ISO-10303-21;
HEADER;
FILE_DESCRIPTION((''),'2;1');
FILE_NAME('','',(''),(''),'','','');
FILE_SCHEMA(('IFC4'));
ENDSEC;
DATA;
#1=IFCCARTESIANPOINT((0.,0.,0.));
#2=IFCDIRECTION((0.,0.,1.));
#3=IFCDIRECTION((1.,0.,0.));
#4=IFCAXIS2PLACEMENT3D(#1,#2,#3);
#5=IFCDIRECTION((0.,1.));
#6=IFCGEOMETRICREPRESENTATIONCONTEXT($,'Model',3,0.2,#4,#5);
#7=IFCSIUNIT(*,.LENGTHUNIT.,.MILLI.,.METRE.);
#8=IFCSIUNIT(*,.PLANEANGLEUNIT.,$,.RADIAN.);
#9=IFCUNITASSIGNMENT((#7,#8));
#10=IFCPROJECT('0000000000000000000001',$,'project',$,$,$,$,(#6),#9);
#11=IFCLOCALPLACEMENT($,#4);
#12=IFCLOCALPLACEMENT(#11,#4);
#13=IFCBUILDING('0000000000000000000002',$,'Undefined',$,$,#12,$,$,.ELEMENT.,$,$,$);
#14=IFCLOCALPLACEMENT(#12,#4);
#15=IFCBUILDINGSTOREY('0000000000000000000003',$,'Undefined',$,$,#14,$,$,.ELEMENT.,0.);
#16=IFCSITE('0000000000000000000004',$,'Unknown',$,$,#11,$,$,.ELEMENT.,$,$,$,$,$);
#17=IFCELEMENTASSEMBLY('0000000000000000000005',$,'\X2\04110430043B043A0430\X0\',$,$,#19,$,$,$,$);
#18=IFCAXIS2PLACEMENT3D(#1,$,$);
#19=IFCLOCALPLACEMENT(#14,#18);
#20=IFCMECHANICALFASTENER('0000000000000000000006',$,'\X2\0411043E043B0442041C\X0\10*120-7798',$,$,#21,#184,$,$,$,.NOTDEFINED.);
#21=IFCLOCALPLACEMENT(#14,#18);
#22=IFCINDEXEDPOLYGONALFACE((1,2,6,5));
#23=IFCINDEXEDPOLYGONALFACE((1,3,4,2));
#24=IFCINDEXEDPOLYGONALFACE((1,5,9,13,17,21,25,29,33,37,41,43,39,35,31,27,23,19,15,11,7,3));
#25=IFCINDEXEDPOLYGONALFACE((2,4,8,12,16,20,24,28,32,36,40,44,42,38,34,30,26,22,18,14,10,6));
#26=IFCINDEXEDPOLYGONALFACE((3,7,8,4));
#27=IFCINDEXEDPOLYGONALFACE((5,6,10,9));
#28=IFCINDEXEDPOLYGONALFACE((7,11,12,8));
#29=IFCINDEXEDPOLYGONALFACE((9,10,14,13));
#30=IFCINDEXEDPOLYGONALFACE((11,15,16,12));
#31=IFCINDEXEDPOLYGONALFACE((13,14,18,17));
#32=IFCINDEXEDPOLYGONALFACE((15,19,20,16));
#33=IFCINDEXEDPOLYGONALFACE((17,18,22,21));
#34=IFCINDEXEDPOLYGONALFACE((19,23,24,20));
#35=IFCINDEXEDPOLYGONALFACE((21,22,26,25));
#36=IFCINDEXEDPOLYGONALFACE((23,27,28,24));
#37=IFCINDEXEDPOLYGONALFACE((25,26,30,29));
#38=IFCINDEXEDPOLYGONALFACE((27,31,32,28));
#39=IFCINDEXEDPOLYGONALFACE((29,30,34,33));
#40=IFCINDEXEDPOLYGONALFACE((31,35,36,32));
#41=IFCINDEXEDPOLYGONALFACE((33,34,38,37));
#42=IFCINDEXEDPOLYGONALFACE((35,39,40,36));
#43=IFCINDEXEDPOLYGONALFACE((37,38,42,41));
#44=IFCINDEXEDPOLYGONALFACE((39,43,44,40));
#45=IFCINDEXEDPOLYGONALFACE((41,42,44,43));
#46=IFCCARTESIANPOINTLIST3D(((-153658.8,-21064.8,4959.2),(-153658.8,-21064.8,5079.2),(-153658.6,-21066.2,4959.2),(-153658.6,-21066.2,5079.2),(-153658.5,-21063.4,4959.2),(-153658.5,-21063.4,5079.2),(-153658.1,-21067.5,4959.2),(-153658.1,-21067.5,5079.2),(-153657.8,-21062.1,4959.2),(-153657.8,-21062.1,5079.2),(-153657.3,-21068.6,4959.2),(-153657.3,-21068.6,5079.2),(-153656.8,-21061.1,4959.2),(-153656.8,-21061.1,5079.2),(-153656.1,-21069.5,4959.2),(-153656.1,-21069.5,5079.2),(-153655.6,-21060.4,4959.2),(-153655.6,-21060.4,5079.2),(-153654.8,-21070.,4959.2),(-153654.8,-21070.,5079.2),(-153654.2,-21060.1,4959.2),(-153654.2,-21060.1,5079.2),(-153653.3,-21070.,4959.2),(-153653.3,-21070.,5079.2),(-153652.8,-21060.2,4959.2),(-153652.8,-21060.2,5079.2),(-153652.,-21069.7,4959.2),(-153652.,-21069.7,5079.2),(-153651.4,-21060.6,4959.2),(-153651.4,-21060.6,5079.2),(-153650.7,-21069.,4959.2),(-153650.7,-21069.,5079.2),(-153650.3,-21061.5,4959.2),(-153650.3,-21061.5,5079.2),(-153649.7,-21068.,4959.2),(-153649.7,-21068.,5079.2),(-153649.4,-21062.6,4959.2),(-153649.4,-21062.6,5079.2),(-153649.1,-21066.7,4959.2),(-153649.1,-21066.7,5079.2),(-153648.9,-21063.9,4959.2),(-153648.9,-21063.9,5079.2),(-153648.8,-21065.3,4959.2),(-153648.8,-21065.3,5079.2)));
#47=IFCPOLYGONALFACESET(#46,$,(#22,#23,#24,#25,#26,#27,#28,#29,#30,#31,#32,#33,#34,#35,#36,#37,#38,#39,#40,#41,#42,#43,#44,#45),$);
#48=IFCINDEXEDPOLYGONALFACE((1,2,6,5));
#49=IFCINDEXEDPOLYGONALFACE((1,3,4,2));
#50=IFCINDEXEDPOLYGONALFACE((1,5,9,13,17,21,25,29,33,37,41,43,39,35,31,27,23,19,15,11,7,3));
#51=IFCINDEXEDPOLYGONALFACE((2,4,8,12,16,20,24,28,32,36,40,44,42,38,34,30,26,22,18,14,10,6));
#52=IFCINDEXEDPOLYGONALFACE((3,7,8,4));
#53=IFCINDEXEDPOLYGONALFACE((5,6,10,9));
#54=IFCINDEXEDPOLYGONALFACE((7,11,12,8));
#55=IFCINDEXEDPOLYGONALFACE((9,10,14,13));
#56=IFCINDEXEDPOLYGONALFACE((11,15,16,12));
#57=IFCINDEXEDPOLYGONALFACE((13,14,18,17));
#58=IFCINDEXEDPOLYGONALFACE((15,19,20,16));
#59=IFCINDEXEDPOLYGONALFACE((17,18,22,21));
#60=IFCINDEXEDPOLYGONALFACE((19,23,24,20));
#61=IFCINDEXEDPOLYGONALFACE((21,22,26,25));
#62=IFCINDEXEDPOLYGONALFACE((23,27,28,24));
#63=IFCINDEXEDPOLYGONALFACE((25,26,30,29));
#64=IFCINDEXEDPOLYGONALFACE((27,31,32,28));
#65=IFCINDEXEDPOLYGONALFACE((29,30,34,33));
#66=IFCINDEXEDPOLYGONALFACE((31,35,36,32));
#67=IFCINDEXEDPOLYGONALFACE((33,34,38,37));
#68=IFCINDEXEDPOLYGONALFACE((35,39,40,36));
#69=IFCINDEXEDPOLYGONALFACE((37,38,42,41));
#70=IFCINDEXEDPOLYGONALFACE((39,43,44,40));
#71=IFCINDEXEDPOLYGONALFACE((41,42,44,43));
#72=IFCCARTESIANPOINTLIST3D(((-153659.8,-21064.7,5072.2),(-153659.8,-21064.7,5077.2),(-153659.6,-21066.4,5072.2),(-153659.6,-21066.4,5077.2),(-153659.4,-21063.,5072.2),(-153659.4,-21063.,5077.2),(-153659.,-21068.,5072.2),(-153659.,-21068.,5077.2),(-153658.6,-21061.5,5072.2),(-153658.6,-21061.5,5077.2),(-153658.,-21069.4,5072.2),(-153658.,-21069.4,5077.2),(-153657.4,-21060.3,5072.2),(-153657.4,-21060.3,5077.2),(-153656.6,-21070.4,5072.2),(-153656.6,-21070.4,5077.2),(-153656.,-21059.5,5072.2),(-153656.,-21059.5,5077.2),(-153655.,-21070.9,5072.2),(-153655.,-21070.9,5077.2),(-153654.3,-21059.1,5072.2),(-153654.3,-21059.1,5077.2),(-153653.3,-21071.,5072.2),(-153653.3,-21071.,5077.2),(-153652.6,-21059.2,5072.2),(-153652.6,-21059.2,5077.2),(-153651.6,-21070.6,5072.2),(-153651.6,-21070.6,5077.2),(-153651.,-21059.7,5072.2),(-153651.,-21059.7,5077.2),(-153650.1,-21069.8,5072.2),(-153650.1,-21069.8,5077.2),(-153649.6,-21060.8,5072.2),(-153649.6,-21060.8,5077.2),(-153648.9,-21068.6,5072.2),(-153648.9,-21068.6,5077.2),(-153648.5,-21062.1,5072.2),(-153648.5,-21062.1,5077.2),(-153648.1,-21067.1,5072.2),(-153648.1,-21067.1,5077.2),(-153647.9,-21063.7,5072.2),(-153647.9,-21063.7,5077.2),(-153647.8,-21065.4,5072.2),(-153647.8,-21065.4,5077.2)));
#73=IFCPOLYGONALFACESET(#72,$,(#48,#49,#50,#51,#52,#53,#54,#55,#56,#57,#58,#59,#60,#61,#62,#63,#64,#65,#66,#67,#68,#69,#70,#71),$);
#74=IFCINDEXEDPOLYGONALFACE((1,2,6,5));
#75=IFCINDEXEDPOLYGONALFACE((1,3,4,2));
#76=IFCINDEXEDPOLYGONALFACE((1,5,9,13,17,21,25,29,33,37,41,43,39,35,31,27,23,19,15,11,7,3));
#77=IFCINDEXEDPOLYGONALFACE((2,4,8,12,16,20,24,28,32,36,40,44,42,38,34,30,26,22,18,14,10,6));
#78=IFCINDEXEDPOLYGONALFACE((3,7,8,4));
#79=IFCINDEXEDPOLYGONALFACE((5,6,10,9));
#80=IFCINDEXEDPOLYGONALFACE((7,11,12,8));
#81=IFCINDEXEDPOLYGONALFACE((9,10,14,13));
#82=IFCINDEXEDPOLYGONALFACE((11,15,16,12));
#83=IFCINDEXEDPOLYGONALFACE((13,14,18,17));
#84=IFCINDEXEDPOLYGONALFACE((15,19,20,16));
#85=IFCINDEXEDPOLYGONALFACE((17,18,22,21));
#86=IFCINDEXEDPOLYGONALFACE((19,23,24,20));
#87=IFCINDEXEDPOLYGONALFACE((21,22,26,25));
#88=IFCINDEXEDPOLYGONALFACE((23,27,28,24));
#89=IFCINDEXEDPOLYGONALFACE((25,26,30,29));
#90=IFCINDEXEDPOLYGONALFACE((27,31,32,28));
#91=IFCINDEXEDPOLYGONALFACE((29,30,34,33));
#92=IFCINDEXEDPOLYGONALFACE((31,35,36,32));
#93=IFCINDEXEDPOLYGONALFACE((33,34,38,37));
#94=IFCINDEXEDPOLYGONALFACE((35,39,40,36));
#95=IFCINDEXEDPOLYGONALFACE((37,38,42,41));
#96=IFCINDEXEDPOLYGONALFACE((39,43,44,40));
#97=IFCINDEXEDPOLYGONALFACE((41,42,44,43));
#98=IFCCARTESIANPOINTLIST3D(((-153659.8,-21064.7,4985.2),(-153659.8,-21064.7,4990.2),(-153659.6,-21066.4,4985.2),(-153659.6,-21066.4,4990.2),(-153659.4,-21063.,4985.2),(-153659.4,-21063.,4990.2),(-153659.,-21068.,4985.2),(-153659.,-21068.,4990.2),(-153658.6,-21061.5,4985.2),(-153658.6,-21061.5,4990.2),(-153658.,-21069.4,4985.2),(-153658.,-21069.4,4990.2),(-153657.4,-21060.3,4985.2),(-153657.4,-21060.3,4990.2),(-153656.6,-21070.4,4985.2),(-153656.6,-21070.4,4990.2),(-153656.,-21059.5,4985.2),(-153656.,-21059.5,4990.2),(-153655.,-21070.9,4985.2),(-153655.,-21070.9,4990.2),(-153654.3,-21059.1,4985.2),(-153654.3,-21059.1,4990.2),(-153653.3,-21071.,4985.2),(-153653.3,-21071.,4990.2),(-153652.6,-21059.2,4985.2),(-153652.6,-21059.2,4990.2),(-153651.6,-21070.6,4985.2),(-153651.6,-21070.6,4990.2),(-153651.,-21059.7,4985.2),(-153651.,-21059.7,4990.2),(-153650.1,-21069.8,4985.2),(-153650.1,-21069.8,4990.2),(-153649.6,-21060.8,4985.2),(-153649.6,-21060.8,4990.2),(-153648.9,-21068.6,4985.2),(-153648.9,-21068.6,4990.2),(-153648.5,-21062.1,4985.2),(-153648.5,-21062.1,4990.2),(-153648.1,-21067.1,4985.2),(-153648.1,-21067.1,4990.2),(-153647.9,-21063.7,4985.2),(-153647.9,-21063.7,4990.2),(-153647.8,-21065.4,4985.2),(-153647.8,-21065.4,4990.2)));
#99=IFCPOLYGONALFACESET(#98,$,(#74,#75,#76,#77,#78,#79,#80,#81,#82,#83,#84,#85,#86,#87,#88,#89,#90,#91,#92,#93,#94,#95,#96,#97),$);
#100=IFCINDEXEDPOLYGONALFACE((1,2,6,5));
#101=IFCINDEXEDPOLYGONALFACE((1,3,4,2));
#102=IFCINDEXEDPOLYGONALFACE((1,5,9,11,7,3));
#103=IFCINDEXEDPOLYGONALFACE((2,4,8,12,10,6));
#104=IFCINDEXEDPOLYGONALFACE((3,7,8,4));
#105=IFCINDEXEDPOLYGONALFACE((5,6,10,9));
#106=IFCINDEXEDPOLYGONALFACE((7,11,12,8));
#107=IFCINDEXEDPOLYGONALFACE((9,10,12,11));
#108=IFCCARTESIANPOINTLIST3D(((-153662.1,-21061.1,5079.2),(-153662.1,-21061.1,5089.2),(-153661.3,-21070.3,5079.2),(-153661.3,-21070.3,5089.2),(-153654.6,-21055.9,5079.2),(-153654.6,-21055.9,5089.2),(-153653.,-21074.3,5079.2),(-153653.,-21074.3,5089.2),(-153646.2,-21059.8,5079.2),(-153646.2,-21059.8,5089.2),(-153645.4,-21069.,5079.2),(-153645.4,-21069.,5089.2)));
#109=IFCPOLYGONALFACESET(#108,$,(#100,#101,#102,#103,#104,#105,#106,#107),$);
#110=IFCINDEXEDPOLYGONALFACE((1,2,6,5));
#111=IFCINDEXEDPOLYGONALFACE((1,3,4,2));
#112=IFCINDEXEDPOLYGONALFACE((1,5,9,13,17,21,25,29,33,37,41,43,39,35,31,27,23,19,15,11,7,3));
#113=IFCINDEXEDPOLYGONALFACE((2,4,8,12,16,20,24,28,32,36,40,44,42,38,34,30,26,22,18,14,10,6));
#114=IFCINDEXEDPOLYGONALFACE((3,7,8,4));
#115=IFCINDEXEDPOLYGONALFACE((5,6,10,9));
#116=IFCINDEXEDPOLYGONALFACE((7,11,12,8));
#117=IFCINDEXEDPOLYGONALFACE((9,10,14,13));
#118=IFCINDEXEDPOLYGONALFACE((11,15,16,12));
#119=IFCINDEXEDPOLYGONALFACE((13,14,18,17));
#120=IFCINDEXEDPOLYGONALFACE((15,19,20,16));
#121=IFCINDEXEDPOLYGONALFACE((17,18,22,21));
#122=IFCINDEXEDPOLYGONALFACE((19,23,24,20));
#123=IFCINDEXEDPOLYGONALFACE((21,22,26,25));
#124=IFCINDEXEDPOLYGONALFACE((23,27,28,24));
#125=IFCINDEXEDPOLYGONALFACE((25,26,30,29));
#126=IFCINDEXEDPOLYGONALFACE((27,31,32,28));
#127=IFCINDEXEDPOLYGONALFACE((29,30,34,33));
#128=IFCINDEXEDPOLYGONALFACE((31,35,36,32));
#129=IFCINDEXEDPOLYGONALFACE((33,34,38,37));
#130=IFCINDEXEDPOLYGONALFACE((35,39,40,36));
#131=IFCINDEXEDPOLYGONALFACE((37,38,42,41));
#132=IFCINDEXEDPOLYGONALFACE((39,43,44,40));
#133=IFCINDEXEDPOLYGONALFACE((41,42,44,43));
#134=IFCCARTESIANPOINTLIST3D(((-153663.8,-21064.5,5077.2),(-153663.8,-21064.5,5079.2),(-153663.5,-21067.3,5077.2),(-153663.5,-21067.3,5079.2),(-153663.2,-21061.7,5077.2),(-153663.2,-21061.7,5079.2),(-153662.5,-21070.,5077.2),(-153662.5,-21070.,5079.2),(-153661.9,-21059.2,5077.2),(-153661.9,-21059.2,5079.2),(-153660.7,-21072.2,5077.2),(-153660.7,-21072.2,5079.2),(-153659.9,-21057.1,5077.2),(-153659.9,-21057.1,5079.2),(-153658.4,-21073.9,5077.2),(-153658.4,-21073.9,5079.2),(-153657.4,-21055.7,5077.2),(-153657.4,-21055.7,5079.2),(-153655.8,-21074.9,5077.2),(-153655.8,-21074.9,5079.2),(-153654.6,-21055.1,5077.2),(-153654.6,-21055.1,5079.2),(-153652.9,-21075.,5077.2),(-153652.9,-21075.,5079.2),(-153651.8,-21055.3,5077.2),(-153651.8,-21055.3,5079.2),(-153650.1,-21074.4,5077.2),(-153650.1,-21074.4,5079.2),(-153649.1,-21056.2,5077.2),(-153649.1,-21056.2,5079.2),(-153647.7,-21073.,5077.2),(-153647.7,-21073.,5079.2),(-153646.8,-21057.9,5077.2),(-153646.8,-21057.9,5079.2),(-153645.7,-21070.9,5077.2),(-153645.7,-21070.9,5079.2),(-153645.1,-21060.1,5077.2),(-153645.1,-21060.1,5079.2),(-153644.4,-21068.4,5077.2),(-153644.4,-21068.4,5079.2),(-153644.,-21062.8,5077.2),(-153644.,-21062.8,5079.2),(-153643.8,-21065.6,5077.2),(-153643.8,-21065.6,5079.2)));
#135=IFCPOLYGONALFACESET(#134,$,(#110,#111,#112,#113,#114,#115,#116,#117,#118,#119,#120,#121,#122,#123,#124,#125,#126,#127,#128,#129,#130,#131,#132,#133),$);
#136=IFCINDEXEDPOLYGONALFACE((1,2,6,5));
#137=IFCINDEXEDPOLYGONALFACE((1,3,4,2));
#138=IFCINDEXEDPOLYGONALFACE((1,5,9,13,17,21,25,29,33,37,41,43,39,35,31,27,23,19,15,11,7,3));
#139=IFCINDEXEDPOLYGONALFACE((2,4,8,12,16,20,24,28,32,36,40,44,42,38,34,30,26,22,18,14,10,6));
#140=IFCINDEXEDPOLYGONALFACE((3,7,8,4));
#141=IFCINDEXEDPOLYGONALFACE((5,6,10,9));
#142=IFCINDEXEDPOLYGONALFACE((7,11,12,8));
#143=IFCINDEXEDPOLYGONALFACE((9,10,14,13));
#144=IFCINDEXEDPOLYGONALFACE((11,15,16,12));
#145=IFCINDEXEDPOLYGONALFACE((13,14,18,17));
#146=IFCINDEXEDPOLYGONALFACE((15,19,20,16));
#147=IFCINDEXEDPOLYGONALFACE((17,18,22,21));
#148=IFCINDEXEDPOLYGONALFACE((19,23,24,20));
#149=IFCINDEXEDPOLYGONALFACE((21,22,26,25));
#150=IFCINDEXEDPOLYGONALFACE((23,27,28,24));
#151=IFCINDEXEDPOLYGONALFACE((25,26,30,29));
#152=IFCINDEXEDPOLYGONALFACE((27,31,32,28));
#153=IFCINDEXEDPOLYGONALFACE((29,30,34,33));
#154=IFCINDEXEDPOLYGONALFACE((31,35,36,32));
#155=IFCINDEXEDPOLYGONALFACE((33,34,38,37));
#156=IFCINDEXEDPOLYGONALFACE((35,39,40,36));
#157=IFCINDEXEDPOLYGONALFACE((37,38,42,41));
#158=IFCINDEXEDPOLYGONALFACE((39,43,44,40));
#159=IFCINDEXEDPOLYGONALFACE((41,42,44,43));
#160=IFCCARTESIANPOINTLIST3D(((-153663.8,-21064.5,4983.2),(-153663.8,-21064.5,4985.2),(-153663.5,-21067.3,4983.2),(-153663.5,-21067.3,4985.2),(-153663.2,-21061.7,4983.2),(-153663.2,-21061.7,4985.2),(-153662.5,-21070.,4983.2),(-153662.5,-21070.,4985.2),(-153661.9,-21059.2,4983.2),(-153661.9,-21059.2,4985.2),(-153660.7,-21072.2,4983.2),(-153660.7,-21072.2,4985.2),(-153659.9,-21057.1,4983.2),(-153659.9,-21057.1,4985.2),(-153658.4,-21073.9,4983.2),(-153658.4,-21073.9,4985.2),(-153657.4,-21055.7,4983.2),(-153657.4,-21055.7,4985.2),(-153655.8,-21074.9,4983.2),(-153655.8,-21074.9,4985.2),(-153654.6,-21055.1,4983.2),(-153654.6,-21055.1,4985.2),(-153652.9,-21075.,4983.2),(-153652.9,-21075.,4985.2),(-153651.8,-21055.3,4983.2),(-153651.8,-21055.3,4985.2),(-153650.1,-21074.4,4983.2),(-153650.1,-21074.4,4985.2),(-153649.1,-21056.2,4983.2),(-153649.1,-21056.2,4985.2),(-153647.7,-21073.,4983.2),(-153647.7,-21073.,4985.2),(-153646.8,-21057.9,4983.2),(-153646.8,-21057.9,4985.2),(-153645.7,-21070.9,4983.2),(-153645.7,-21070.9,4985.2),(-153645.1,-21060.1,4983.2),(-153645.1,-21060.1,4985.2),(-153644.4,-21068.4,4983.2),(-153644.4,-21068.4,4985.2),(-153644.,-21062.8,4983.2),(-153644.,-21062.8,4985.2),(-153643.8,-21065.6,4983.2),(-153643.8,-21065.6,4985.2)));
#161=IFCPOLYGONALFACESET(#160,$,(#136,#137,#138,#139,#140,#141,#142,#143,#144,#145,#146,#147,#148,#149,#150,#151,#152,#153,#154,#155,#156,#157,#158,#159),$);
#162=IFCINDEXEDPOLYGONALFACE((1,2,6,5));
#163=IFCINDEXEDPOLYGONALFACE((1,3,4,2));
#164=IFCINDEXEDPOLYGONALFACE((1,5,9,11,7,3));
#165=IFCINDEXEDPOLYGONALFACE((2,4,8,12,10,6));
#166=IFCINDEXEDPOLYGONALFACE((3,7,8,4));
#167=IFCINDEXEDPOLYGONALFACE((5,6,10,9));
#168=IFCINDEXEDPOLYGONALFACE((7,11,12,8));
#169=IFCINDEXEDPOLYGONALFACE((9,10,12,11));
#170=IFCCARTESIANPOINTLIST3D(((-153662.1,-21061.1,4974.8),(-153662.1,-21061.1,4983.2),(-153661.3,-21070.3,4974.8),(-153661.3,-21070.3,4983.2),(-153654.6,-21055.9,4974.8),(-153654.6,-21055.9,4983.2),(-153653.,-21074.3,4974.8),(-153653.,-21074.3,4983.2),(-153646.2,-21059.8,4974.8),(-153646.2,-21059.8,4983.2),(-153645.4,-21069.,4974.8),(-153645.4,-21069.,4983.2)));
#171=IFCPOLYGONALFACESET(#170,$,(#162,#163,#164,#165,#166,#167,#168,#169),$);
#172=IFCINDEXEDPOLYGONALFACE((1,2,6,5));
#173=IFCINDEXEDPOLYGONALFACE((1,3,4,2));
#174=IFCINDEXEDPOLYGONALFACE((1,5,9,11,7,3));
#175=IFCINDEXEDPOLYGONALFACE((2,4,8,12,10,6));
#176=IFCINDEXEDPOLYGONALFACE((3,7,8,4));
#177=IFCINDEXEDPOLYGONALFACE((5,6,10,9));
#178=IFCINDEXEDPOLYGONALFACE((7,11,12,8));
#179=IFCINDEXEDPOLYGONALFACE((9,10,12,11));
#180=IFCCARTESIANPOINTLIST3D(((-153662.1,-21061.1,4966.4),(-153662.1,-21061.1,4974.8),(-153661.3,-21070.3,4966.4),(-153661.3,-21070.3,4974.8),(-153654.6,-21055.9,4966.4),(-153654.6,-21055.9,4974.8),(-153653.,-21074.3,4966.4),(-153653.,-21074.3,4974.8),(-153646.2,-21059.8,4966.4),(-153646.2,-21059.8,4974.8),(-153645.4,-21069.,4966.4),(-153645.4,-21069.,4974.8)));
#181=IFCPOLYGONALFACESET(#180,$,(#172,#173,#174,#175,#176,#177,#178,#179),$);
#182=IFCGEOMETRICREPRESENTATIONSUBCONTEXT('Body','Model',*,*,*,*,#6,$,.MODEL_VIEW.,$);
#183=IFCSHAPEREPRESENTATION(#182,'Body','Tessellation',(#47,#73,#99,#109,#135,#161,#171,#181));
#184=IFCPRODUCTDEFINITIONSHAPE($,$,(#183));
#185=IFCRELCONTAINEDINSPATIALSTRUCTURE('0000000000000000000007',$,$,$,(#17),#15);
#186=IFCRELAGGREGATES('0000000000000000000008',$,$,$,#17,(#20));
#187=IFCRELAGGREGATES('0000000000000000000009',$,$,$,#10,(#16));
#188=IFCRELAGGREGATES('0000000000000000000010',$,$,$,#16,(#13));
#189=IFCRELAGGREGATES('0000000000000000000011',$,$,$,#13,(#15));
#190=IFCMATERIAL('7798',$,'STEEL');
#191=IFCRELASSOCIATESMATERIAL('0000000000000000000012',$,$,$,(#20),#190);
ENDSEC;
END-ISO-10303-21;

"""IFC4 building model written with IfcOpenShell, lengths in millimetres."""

from ifc_helpers import new_model, si_unit, direction, frame, origin_with_axes, place, context, subcontext, project, spatial, line, arc, indexed_curve, outline, extrude, source, transform, mapped, material, element, aggregate, save


model = new_model("IFC4")

# Units and contexts
model_context = context("Model", 3, precision=0.2, world=origin_with_axes(), true_north=direction((0.0, 1.0)))
body_context = subcontext(model_context, "Body", "Model", "MODEL_VIEW")
ifc_project = project(units=[si_unit("LENGTHUNIT", "METRE", prefix="MILLI"), si_unit("PLANEANGLEUNIT", "RADIAN")], contexts=[model_context])

# Site, building, storey
site_placement = place(None, origin_with_axes())
site = spatial("IfcSite", under=ifc_project, at=site_placement, Name="Unknown", CompositionType="ELEMENT")
building_placement = place(site_placement, origin_with_axes())
building = spatial("IfcBuilding", under=site, at=building_placement, Name="Undefined", CompositionType="ELEMENT")
storey_placement = place(building_placement, origin_with_axes())
storey = spatial("IfcBuildingStorey", under=building, at=storey_placement, Name="Undefined", CompositionType="ELEMENT", Elevation=0.0)

# Element assembly
assembly_1_placement = place(storey_placement, frame((-153801.7, -21077.8, 5121.2), z_axis=(0.996285, 0.086114, 0.0), x_axis=(0.0, 0.0, -1.0)))
assembly_1 = element("IfcElementAssembly", 1, at=assembly_1_placement, inside=storey, Name="Балка")

# Shared definitions
ifc_material_1 = material(Name="7798", Category="STEEL")

# Mechanical fastener
shared_shape_1 = source(origin_with_axes(), body_context, "Body", "SweptSolid", [
    extrude(outline(indexed_curve([(5.0, 0.0), (0.0, 5.0), (-5.0, 0.0), (0.0, -5.0)], segments=[arc(1, 2, 3), arc(3, 4, 1)])), frame((0.0, 0.0, 7.0), z_axis=(0.0, 0.0, -1.0), x_axis=(0.0, 1.0, 0.0)), (0.0, 0.0, 1.0), 120.0),
    extrude(outline(indexed_curve([(6.0, 0.0), (0.0, 6.0), (-6.0, 0.0), (0.0, -6.0)], segments=[arc(1, 2, 3), arc(3, 4, 1)])), frame((0.0, 0.0, 5.0), z_axis=(0.0, 0.0, -1.0), x_axis=(0.0, 1.0, 0.0)), (0.0, 0.0, 1.0), 5.0),
    extrude(outline(indexed_curve([(6.0, 0.0), (0.0, 6.0), (-6.0, 0.0), (0.0, -6.0)], segments=[arc(1, 2, 3), arc(3, 4, 1)])), frame((0.0, 0.0, -82.0), z_axis=(0.0, 0.0, -1.0), x_axis=(0.0, 1.0, 0.0)), (0.0, 0.0, 1.0), 5.0),
    extrude(outline(indexed_curve([(9.2, 0.0), (4.6, 8.0), (-4.6, 8.0), (-9.2, 0.0), (-4.6, -8.0), (4.6, -8.0)], segments=[line(1, 2, 3, 4, 5, 6, 1)])), frame((0.0, 0.0, 17.0), z_axis=(0.0, 0.0, -1.0), x_axis=(0.0, 1.0, 0.0)), (0.0, 0.0, 1.0), 10.0),
    extrude(outline(indexed_curve([(10.0, 0.0), (0.0, 10.0), (-10.0, 0.0), (0.0, -10.0)], segments=[arc(1, 2, 3), arc(3, 4, 1)])), frame((0.0, 0.0, 7.0), z_axis=(0.0, 0.0, -1.0), x_axis=(0.0, 1.0, 0.0)), (0.0, 0.0, 1.0), 2.0),
    extrude(outline(indexed_curve([(10.0, 0.0), (0.0, 10.0), (-10.0, 0.0), (0.0, -10.0)], segments=[arc(1, 2, 3), arc(3, 4, 1)])), frame((0.0, 0.0, -87.0), z_axis=(0.0, 0.0, -1.0), x_axis=(0.0, 1.0, 0.0)), (0.0, 0.0, 1.0), 2.0),
    extrude(outline(indexed_curve([(9.2, 0.0), (4.6, 8.0), (-4.6, 8.0), (-9.2, 0.0), (-4.6, -8.0), (4.6, -8.0)], segments=[line(1, 2, 3, 4, 5, 6, 1)])), frame((0.0, 0.0, -89.0), z_axis=(0.0, 0.0, -1.0), x_axis=(0.0, 1.0, 0.0)), (0.0, 0.0, 1.0), 8.4),
    extrude(outline(indexed_curve([(9.2, 0.0), (4.6, 8.0), (-4.6, 8.0), (-9.2, 0.0), (-4.6, -8.0), (4.6, -8.0)], segments=[line(1, 2, 3, 4, 5, 6, 1)])), frame((0.0, 0.0, -97.4), z_axis=(0.0, 0.0, -1.0), x_axis=(0.0, 1.0, 0.0)), (0.0, 0.0, 1.0), 8.4),
])
mechanical_fastener_1_placement = place(assembly_1_placement, frame((49.0, 0.0, 148.5), z_axis=(-1.0, 0.0, 0.0), x_axis=(0.0, 0.0, -1.0)))
mechanical_fastener_1 = element("IfcMechanicalFastener", 2, at=mechanical_fastener_1_placement, material=ifc_material_1, Name="БолтМ10*120-7798", PredefinedType="NOTDEFINED", context=body_context, shape_type="MappedRepresentation", body=[
    mapped(shared_shape_1, transform((0.0, 0.0, 0.0))),
])
aggregate(assembly_1, [mechanical_fastener_1])

save(model, "model.ifc")
